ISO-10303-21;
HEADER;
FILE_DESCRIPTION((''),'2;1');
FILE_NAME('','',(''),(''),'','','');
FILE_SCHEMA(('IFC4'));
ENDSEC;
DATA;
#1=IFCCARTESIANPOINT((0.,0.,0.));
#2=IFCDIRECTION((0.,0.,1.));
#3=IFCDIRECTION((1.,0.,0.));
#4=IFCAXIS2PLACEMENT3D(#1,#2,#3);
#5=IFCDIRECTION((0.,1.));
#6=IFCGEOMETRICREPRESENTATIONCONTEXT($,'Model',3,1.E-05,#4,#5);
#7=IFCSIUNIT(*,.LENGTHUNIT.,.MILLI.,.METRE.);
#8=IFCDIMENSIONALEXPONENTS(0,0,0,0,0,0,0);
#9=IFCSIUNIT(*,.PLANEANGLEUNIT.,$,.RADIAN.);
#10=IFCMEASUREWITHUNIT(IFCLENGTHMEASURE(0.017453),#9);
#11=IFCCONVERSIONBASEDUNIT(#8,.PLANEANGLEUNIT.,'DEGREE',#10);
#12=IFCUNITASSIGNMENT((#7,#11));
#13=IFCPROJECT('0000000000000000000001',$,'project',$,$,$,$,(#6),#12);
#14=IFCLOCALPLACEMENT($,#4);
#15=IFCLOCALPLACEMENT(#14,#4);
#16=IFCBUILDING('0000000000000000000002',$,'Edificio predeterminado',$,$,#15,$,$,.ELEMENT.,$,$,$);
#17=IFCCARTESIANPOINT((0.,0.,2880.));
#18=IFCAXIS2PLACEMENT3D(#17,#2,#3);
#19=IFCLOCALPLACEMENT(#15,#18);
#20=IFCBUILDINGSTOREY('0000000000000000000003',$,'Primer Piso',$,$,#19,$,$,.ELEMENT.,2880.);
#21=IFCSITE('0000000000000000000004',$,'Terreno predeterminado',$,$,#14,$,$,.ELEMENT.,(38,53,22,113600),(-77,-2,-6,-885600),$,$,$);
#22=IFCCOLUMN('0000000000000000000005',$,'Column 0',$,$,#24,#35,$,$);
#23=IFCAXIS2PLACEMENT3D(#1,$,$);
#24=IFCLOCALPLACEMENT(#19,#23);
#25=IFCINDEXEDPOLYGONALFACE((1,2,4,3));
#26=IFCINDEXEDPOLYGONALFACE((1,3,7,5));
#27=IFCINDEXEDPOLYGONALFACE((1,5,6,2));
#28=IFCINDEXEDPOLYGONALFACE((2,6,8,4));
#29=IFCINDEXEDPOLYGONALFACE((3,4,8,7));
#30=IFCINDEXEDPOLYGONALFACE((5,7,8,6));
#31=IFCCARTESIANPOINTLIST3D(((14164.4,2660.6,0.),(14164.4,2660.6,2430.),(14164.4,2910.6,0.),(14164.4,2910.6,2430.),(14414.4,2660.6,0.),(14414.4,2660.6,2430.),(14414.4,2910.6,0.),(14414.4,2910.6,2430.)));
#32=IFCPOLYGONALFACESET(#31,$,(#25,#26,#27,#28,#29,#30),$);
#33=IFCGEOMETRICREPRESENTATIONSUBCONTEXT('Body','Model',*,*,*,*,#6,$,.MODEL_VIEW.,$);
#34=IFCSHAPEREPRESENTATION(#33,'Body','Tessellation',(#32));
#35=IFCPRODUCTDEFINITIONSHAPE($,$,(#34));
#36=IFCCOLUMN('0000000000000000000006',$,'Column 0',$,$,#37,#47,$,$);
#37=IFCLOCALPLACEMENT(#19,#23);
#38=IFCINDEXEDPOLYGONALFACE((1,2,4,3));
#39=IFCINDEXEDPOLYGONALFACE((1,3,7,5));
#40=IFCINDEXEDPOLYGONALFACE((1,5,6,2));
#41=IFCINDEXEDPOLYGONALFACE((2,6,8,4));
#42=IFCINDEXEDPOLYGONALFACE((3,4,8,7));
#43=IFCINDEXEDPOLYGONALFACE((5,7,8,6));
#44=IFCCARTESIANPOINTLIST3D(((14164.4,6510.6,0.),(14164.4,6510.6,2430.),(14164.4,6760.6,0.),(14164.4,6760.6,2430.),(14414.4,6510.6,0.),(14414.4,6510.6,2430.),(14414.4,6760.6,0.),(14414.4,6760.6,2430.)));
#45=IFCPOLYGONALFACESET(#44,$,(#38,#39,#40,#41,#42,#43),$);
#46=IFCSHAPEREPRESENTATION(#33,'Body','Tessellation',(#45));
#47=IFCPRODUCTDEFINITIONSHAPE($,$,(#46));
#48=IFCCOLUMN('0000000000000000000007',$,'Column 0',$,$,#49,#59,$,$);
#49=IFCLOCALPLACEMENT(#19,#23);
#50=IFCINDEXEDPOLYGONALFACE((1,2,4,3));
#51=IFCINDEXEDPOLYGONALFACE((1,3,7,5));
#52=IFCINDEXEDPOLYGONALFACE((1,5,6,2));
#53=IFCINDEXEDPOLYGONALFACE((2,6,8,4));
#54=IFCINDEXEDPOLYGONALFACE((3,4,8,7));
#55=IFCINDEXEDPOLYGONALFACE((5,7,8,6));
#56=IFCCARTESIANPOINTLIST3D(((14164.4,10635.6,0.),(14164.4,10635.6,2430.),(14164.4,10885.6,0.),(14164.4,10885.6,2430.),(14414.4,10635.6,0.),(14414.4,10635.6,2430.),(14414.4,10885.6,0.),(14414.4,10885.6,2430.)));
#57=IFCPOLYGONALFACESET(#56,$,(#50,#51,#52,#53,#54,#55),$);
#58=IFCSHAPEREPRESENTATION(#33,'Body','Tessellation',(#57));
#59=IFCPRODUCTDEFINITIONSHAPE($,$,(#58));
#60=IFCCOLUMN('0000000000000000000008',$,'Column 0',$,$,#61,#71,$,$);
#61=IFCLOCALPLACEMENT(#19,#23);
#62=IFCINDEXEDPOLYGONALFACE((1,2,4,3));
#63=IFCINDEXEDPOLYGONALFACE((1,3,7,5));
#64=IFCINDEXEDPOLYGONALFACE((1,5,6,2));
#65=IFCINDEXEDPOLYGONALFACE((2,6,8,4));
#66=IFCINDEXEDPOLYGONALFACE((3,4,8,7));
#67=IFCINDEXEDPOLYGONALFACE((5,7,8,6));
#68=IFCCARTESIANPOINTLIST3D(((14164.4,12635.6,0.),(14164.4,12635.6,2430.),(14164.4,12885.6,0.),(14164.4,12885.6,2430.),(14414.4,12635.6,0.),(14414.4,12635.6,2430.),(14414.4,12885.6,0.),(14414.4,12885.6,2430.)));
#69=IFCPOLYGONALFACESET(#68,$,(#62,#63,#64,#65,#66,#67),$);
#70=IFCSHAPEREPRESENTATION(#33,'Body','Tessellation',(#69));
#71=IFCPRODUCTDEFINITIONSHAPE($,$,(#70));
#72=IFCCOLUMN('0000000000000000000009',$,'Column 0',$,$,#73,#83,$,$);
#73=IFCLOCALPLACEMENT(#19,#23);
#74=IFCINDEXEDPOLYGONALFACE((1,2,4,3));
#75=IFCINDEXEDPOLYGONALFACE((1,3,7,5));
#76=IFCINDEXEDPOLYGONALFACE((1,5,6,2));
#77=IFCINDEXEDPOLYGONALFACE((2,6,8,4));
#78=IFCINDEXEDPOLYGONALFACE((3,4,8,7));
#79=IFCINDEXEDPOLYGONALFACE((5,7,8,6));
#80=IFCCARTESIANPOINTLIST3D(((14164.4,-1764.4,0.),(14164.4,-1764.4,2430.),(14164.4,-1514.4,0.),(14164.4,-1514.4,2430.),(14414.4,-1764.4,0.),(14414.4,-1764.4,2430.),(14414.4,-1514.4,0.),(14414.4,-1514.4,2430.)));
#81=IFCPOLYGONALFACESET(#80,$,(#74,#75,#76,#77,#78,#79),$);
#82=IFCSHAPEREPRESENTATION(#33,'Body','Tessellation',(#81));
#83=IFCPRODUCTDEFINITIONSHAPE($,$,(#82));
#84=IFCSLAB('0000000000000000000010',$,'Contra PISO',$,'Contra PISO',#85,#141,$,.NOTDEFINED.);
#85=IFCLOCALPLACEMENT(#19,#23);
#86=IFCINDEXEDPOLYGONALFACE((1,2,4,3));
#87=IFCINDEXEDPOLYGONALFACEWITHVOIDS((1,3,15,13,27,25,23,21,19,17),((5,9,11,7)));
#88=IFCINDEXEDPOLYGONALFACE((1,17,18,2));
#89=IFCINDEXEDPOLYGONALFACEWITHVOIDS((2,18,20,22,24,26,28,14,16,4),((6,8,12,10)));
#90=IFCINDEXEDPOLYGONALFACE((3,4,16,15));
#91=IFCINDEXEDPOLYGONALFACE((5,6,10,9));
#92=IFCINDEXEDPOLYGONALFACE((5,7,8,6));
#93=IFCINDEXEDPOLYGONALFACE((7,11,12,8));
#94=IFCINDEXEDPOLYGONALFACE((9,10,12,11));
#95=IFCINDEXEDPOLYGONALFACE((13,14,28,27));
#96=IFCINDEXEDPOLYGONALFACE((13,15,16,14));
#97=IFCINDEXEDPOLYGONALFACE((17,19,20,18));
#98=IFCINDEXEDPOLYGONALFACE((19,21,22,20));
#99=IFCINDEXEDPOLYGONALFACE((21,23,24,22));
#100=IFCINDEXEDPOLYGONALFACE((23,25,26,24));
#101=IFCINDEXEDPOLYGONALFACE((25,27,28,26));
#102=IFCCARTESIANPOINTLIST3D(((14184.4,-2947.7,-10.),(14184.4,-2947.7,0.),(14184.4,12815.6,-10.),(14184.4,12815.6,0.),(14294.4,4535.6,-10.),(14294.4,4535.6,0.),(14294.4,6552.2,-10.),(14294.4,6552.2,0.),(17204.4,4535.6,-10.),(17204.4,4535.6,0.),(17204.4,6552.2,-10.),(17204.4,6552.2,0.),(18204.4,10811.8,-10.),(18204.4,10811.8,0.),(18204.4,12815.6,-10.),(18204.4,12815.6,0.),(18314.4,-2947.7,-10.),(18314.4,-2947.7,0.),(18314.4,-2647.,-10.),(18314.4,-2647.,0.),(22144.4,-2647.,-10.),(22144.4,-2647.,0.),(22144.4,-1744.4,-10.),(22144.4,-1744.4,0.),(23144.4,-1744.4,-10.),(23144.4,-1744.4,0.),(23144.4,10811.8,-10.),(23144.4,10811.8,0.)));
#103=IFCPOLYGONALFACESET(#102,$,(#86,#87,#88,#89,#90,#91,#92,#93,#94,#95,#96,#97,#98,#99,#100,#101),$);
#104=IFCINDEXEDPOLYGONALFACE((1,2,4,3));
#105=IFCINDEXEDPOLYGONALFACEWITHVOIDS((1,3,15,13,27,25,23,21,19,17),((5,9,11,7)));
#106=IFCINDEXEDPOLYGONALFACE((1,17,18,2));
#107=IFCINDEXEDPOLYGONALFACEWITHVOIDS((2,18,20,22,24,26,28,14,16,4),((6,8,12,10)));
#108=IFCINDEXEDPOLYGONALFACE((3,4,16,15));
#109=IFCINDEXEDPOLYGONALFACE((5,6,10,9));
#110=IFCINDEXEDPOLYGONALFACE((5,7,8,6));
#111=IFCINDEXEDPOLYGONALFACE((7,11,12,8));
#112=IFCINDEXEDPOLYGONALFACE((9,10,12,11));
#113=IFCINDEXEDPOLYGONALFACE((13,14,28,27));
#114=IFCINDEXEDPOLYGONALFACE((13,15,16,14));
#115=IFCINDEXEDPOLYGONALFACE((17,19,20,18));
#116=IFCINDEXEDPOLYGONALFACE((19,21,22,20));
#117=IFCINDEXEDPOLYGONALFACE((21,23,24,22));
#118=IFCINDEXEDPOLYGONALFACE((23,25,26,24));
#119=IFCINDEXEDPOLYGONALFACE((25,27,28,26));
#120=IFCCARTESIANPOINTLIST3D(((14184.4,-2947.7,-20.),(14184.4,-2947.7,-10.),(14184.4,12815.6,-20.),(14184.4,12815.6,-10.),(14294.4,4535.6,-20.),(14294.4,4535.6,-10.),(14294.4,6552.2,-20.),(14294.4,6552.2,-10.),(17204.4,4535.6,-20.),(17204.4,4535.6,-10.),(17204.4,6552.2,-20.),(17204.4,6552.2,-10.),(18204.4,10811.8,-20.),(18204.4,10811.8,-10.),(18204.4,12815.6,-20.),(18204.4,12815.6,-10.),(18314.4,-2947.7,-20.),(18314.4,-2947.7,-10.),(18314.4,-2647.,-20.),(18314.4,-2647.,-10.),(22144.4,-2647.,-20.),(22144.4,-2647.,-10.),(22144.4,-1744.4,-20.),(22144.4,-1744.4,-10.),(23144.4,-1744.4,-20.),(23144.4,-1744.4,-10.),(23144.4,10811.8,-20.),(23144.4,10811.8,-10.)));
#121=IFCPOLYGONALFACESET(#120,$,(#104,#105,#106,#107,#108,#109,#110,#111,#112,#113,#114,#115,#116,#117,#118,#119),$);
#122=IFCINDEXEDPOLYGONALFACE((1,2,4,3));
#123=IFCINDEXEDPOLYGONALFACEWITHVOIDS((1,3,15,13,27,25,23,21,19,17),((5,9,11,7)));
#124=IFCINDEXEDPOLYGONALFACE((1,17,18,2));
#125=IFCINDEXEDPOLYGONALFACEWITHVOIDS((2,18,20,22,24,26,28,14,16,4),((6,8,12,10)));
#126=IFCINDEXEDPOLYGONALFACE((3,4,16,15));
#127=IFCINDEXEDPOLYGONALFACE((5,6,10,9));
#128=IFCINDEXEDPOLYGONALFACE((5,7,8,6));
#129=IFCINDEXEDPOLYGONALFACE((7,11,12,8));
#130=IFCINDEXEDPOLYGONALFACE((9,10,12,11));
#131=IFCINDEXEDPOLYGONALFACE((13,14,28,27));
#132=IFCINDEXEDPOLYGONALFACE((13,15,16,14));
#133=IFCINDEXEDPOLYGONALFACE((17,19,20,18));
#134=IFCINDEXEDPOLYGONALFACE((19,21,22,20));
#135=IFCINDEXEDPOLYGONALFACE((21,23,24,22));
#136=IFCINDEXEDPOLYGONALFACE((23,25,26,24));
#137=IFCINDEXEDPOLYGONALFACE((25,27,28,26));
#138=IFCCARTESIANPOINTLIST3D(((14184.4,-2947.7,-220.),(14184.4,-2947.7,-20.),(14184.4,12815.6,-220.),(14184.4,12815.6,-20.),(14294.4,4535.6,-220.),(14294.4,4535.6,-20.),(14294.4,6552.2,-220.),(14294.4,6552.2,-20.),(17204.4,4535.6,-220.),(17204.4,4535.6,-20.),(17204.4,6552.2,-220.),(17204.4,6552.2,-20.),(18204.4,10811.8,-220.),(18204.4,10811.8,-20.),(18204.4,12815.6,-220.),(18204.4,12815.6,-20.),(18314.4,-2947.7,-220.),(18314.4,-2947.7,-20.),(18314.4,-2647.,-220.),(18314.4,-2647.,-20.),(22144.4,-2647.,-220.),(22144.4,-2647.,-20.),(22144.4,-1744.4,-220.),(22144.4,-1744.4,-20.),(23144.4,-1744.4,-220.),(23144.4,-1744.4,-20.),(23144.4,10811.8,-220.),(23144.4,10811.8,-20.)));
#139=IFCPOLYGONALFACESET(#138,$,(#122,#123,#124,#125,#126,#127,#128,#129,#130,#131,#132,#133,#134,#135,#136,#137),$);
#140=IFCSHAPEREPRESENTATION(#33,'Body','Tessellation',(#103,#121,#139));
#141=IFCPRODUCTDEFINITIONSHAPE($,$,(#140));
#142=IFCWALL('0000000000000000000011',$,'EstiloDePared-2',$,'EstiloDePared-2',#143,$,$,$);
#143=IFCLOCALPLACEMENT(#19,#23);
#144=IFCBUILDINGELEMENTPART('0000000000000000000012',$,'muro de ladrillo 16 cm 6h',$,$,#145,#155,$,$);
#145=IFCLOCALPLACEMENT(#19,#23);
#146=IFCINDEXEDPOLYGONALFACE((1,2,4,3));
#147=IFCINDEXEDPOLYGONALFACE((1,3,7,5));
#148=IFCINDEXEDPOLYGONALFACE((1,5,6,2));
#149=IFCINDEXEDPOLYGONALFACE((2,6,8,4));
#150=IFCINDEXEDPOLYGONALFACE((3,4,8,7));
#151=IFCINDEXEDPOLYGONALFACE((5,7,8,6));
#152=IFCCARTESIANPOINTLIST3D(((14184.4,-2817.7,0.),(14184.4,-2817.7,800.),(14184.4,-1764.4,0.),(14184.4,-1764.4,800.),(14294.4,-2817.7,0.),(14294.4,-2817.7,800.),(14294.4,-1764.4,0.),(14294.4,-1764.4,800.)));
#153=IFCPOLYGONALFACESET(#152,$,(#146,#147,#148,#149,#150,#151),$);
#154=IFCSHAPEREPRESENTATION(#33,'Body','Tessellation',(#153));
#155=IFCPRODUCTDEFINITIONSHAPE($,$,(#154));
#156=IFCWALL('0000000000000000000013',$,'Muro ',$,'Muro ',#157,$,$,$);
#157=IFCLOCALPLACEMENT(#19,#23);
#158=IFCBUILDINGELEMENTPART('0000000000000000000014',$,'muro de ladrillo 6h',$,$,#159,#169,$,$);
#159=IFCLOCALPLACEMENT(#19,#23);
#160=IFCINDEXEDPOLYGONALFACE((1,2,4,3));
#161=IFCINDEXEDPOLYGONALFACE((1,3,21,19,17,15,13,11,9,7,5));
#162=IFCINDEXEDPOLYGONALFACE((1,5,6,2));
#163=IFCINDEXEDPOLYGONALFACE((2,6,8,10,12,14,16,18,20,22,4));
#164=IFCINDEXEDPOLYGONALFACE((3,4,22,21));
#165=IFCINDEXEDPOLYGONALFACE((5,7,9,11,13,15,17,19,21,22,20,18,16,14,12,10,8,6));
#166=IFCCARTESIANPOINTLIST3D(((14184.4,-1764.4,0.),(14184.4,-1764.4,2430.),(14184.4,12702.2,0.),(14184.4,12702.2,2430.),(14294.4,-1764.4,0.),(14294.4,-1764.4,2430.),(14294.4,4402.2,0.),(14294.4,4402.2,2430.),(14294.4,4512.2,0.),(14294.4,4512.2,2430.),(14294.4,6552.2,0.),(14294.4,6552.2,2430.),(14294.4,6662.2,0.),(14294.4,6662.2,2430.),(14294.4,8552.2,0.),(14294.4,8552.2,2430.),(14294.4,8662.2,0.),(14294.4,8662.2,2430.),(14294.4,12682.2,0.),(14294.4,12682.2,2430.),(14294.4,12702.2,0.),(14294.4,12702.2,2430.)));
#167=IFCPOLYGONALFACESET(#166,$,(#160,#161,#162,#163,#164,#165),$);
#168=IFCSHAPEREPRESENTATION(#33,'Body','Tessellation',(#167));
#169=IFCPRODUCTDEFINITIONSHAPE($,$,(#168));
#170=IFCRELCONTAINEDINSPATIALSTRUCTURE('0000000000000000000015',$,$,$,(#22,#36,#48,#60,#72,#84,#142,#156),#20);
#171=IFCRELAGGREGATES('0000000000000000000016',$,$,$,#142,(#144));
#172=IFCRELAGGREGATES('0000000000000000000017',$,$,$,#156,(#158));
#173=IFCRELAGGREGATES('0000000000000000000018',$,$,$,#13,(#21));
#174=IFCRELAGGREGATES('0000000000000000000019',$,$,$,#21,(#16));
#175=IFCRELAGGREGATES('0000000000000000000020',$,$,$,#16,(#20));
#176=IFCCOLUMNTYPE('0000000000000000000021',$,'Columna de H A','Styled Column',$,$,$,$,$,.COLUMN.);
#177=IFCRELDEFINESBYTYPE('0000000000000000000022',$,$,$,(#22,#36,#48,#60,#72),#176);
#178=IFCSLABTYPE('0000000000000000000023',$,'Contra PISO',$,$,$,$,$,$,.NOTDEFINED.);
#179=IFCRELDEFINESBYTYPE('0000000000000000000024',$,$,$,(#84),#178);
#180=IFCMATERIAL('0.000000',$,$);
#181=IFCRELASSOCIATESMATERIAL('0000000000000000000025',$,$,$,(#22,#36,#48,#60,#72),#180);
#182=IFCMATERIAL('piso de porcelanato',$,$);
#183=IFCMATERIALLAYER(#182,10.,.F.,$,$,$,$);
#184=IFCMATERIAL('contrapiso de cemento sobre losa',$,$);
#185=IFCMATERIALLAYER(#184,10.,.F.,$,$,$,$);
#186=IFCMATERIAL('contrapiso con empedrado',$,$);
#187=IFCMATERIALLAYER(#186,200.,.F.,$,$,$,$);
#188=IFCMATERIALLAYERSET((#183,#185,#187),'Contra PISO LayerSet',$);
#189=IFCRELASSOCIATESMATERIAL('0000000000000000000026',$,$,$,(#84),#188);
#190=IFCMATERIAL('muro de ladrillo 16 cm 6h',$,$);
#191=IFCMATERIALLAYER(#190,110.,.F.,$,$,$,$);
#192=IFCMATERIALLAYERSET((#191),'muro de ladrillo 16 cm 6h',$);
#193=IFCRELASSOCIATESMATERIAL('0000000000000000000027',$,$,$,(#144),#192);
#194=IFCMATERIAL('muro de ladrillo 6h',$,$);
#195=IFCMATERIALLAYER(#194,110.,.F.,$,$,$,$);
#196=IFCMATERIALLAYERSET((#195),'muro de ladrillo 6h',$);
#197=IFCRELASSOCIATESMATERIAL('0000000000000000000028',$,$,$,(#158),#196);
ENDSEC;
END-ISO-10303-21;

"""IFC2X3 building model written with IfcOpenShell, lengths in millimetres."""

from ifc_helpers import new_model, entity, si_unit, converted_unit, direction, frame, origin_with_axes, place, context, subcontext, project, spatial, polyline, outline, extrude, material, layer, layer_set, layer_usage, type_object, element, aggregate, save


model = new_model("IFC2X3")

# Units and contexts
model_context = context("Model", 3, precision=1e-05, world=origin_with_axes(), true_north=direction((0.0, 1.0)))
body_context = subcontext(model_context, "Body", "Model", "MODEL_VIEW")
ifc_project = project(units=[si_unit("LENGTHUNIT", "METRE", prefix="MILLI"), converted_unit("PLANEANGLEUNIT", "DEGREE", entity("IfcLengthMeasure", 0.017453), si_unit("PLANEANGLEUNIT", "RADIAN"), dimensions=[0, 0, 0, 0, 0, 0, 0])], contexts=[model_context])

# Site, building, storey
site_placement = place(None, origin_with_axes())
site = spatial("IfcSite", under=ifc_project, at=site_placement, Name="Terreno predeterminado", CompositionType="ELEMENT", RefLatitude=(38, 53, 22, 113600), RefLongitude=(-77, -2, -6, -885600))
building_placement = place(site_placement, origin_with_axes())
building = spatial("IfcBuilding", under=site, at=building_placement, Name="Edificio predeterminado", CompositionType="ELEMENT")
storey_placement = place(building_placement, frame((0.0, 0.0, 2880.0), z_axis=(0.0, 0.0, 1.0), x_axis=(1.0, 0.0, 0.0)))
storey = spatial("IfcBuildingStorey", under=building, at=storey_placement, Name="Primer Piso", CompositionType="ELEMENT", Elevation=2880.0)

# Columns
ifc_material_1 = material(Name="0.000000")
column_type = type_object("IfcColumnType", Name="Columna de H A", Description="Styled Column", PredefinedType="COLUMN")
for number, where, z_axis, x_axis, name in (
    (1, (14289.4, 2785.6, 0.0), (0.0, 0.0, 1.0), (1.0, 0.0, 0.0), "Column 0"),
    (2, (14289.4, 6635.6, 0.0), (0.0, 0.0, 1.0), (1.0, 0.0, 0.0), "Column 0"),
    (3, (14289.4, 10760.6, 0.0), (0.0, 0.0, 1.0), (1.0, 0.0, 0.0), "Column 0"),
    (4, (14289.4, 12760.6, 0.0), (0.0, 0.0, 1.0), (1.0, 0.0, 0.0), "Column 0"),
    (5, (14289.4, -1639.4, 0.0), (0.0, 0.0, 1.0), (1.0, 0.0, 0.0), "Column 0"),
):
    element("IfcColumn", number, at=place(storey_placement, frame(where, z_axis=z_axis, x_axis=x_axis)), inside=storey, type_object=column_type, material=ifc_material_1, Name=name, context=body_context, shape_type="SweptSolid", body=[
        extrude(outline(polyline([(-125.0, -125.0), (125.0, -125.0), (125.0, 125.0), (-125.0, 125.0), (-125.0, -125.0)])), origin_with_axes(), (0.0, 0.0, 1.0), 2430.0),
    ])

# Slab
ifc_material_2 = material(Name="piso de porcelanato")
ifc_layer_1 = layer(ifc_material_2, 10.0, ventilated=False)
ifc_material_3 = material(Name="contrapiso de cemento sobre losa")
ifc_layer_2 = layer(ifc_material_3, 10.0, ventilated=False)
ifc_material_4 = material(Name="contrapiso con empedrado")
ifc_layer_3 = layer(ifc_material_4, 200.0, ventilated=False)
ifc_layer_set_1 = layer_set([ifc_layer_1, ifc_layer_2, ifc_layer_3], Name="Contra PISO LayerSet")
ifc_layer_usage_1 = layer_usage(ifc_layer_set_1, "AXIS3", "NEGATIVE", 0.0)
slab_type = type_object("IfcSlabType", Name="Contra PISO", PredefinedType="NOTDEFINED")
slab_placement = place(storey_placement, frame((0.0, 0.0, -2880.0), z_axis=(0.0, 0.0, 1.0), x_axis=(1.0, 0.0, 0.0)))
element("IfcSlab", 6, at=slab_placement, inside=storey, type_object=slab_type, material=ifc_layer_usage_1, Name="Contra PISO", ObjectType="Contra PISO", PredefinedType="NOTDEFINED", context=body_context, shape_type="SweptSolid", body=[
    extrude(outline(polyline([(0.0, 15763.4), (4130.0, 15763.4), (4130.0, 15462.6), (7960.0, 15462.6), (7960.0, 14560.0), (8960.0, 14560.0), (8960.0, 2003.8), (4020.0, 2003.8), (4020.0, 0.0), (0.0, 0.0), (0.0, 15763.4)]), holes=[polyline([(110.0, 6263.4), (3020.0, 6263.4), (3020.0, 8280.0), (110.0, 8280.0), (110.0, 6263.4)])]), frame((14184.4, 12815.6, 2870.0), z_axis=(0.0, 0.0, -1.0), x_axis=(1.0, 0.0, 0.0)), (0.0, 0.0, -1.0), 10.0),
    extrude(outline(polyline([(0.0, 15763.4), (4130.0, 15763.4), (4130.0, 15462.6), (7960.0, 15462.6), (7960.0, 14560.0), (8960.0, 14560.0), (8960.0, 2003.8), (4020.0, 2003.8), (4020.0, 0.0), (0.0, 0.0), (0.0, 15763.4)]), holes=[polyline([(110.0, 6263.4), (3020.0, 6263.4), (3020.0, 8280.0), (110.0, 8280.0), (110.0, 6263.4)])]), frame((14184.4, 12815.6, 2860.0), z_axis=(0.0, 0.0, -1.0), x_axis=(1.0, 0.0, 0.0)), (0.0, 0.0, -1.0), 10.0),
    extrude(outline(polyline([(0.0, 15763.4), (4130.0, 15763.4), (4130.0, 15462.6), (7960.0, 15462.6), (7960.0, 14560.0), (8960.0, 14560.0), (8960.0, 2003.8), (4020.0, 2003.8), (4020.0, 0.0), (0.0, 0.0), (0.0, 15763.4)]), holes=[polyline([(110.0, 6263.4), (3020.0, 6263.4), (3020.0, 8280.0), (110.0, 8280.0), (110.0, 6263.4)])]), frame((14184.4, 12815.6, 2660.0), z_axis=(0.0, 0.0, -1.0), x_axis=(1.0, 0.0, 0.0)), (0.0, 0.0, -1.0), 200.0),
])

# Walls, building element parts
wall_1_placement = place(storey_placement, frame((14239.4, -2817.7, 0.0), z_axis=(0.0, 0.0, 1.0), x_axis=(0.0, 1.0, 0.0)))
wall_1 = element("IfcWall", 7, at=wall_1_placement, inside=storey, Name="EstiloDePared-2", ObjectType="EstiloDePared-2")
ifc_material_5 = material(Name="muro de ladrillo 16 cm 6h")
ifc_layer_4 = layer(ifc_material_5, 110.0, ventilated=False)
ifc_layer_set_2 = layer_set([ifc_layer_4], Name="muro de ladrillo 16 cm 6h")
ifc_layer_usage_2 = layer_usage(ifc_layer_set_2, "AXIS2", "NEGATIVE", -55.0)
building_element_part_1_placement = place(wall_1_placement, origin_with_axes())
building_element_part_1 = element("IfcBuildingElementPart", 8, at=building_element_part_1_placement, material=ifc_layer_usage_2, Name="muro de ladrillo 16 cm 6h", context=body_context, shape_type="SweptSolid", body=[
    extrude(outline(polyline([(1053.4, 55.0), (1053.4, -55.0), (0.0, -55.0), (0.0, 55.0), (1053.4, 55.0)])), origin_with_axes(), (0.0, 0.0, 1.0), 800.0),
])
aggregate(wall_1, [building_element_part_1])
wall_2_placement = place(storey_placement, frame((14239.4, -1764.4, 0.0), z_axis=(0.0, 0.0, 1.0), x_axis=(0.0, 1.0, 0.0)))
wall_2 = element("IfcWall", 9, at=wall_2_placement, inside=storey, Name="Muro ", ObjectType="Muro ")
ifc_material_6 = material(Name="muro de ladrillo 6h")
ifc_layer_5 = layer(ifc_material_6, 110.0, ventilated=False)
ifc_layer_set_3 = layer_set([ifc_layer_5], Name="muro de ladrillo 6h")
ifc_layer_usage_3 = layer_usage(ifc_layer_set_3, "AXIS2", "NEGATIVE", -55.0)
building_element_part_2_placement = place(wall_2_placement, origin_with_axes())
building_element_part_2 = element("IfcBuildingElementPart", 10, at=building_element_part_2_placement, material=ifc_layer_usage_3, Name="muro de ladrillo 6h", context=body_context, shape_type="SweptSolid", body=[
    extrude(outline(polyline([(14466.6, 55.0), (14466.6, -55.0), (14446.6, -55.0), (10426.6, -55.0), (10316.6, -55.0), (8426.6, -55.0), (8316.6, -55.0), (6276.6, -55.0), (6166.6, -55.0), (0.0, -55.0), (0.0, 55.0), (14466.6, 55.0)])), origin_with_axes(), (0.0, 0.0, 1.0), 2430.0),
])
aggregate(wall_2, [building_element_part_2])

save(model, "model.ifc")
